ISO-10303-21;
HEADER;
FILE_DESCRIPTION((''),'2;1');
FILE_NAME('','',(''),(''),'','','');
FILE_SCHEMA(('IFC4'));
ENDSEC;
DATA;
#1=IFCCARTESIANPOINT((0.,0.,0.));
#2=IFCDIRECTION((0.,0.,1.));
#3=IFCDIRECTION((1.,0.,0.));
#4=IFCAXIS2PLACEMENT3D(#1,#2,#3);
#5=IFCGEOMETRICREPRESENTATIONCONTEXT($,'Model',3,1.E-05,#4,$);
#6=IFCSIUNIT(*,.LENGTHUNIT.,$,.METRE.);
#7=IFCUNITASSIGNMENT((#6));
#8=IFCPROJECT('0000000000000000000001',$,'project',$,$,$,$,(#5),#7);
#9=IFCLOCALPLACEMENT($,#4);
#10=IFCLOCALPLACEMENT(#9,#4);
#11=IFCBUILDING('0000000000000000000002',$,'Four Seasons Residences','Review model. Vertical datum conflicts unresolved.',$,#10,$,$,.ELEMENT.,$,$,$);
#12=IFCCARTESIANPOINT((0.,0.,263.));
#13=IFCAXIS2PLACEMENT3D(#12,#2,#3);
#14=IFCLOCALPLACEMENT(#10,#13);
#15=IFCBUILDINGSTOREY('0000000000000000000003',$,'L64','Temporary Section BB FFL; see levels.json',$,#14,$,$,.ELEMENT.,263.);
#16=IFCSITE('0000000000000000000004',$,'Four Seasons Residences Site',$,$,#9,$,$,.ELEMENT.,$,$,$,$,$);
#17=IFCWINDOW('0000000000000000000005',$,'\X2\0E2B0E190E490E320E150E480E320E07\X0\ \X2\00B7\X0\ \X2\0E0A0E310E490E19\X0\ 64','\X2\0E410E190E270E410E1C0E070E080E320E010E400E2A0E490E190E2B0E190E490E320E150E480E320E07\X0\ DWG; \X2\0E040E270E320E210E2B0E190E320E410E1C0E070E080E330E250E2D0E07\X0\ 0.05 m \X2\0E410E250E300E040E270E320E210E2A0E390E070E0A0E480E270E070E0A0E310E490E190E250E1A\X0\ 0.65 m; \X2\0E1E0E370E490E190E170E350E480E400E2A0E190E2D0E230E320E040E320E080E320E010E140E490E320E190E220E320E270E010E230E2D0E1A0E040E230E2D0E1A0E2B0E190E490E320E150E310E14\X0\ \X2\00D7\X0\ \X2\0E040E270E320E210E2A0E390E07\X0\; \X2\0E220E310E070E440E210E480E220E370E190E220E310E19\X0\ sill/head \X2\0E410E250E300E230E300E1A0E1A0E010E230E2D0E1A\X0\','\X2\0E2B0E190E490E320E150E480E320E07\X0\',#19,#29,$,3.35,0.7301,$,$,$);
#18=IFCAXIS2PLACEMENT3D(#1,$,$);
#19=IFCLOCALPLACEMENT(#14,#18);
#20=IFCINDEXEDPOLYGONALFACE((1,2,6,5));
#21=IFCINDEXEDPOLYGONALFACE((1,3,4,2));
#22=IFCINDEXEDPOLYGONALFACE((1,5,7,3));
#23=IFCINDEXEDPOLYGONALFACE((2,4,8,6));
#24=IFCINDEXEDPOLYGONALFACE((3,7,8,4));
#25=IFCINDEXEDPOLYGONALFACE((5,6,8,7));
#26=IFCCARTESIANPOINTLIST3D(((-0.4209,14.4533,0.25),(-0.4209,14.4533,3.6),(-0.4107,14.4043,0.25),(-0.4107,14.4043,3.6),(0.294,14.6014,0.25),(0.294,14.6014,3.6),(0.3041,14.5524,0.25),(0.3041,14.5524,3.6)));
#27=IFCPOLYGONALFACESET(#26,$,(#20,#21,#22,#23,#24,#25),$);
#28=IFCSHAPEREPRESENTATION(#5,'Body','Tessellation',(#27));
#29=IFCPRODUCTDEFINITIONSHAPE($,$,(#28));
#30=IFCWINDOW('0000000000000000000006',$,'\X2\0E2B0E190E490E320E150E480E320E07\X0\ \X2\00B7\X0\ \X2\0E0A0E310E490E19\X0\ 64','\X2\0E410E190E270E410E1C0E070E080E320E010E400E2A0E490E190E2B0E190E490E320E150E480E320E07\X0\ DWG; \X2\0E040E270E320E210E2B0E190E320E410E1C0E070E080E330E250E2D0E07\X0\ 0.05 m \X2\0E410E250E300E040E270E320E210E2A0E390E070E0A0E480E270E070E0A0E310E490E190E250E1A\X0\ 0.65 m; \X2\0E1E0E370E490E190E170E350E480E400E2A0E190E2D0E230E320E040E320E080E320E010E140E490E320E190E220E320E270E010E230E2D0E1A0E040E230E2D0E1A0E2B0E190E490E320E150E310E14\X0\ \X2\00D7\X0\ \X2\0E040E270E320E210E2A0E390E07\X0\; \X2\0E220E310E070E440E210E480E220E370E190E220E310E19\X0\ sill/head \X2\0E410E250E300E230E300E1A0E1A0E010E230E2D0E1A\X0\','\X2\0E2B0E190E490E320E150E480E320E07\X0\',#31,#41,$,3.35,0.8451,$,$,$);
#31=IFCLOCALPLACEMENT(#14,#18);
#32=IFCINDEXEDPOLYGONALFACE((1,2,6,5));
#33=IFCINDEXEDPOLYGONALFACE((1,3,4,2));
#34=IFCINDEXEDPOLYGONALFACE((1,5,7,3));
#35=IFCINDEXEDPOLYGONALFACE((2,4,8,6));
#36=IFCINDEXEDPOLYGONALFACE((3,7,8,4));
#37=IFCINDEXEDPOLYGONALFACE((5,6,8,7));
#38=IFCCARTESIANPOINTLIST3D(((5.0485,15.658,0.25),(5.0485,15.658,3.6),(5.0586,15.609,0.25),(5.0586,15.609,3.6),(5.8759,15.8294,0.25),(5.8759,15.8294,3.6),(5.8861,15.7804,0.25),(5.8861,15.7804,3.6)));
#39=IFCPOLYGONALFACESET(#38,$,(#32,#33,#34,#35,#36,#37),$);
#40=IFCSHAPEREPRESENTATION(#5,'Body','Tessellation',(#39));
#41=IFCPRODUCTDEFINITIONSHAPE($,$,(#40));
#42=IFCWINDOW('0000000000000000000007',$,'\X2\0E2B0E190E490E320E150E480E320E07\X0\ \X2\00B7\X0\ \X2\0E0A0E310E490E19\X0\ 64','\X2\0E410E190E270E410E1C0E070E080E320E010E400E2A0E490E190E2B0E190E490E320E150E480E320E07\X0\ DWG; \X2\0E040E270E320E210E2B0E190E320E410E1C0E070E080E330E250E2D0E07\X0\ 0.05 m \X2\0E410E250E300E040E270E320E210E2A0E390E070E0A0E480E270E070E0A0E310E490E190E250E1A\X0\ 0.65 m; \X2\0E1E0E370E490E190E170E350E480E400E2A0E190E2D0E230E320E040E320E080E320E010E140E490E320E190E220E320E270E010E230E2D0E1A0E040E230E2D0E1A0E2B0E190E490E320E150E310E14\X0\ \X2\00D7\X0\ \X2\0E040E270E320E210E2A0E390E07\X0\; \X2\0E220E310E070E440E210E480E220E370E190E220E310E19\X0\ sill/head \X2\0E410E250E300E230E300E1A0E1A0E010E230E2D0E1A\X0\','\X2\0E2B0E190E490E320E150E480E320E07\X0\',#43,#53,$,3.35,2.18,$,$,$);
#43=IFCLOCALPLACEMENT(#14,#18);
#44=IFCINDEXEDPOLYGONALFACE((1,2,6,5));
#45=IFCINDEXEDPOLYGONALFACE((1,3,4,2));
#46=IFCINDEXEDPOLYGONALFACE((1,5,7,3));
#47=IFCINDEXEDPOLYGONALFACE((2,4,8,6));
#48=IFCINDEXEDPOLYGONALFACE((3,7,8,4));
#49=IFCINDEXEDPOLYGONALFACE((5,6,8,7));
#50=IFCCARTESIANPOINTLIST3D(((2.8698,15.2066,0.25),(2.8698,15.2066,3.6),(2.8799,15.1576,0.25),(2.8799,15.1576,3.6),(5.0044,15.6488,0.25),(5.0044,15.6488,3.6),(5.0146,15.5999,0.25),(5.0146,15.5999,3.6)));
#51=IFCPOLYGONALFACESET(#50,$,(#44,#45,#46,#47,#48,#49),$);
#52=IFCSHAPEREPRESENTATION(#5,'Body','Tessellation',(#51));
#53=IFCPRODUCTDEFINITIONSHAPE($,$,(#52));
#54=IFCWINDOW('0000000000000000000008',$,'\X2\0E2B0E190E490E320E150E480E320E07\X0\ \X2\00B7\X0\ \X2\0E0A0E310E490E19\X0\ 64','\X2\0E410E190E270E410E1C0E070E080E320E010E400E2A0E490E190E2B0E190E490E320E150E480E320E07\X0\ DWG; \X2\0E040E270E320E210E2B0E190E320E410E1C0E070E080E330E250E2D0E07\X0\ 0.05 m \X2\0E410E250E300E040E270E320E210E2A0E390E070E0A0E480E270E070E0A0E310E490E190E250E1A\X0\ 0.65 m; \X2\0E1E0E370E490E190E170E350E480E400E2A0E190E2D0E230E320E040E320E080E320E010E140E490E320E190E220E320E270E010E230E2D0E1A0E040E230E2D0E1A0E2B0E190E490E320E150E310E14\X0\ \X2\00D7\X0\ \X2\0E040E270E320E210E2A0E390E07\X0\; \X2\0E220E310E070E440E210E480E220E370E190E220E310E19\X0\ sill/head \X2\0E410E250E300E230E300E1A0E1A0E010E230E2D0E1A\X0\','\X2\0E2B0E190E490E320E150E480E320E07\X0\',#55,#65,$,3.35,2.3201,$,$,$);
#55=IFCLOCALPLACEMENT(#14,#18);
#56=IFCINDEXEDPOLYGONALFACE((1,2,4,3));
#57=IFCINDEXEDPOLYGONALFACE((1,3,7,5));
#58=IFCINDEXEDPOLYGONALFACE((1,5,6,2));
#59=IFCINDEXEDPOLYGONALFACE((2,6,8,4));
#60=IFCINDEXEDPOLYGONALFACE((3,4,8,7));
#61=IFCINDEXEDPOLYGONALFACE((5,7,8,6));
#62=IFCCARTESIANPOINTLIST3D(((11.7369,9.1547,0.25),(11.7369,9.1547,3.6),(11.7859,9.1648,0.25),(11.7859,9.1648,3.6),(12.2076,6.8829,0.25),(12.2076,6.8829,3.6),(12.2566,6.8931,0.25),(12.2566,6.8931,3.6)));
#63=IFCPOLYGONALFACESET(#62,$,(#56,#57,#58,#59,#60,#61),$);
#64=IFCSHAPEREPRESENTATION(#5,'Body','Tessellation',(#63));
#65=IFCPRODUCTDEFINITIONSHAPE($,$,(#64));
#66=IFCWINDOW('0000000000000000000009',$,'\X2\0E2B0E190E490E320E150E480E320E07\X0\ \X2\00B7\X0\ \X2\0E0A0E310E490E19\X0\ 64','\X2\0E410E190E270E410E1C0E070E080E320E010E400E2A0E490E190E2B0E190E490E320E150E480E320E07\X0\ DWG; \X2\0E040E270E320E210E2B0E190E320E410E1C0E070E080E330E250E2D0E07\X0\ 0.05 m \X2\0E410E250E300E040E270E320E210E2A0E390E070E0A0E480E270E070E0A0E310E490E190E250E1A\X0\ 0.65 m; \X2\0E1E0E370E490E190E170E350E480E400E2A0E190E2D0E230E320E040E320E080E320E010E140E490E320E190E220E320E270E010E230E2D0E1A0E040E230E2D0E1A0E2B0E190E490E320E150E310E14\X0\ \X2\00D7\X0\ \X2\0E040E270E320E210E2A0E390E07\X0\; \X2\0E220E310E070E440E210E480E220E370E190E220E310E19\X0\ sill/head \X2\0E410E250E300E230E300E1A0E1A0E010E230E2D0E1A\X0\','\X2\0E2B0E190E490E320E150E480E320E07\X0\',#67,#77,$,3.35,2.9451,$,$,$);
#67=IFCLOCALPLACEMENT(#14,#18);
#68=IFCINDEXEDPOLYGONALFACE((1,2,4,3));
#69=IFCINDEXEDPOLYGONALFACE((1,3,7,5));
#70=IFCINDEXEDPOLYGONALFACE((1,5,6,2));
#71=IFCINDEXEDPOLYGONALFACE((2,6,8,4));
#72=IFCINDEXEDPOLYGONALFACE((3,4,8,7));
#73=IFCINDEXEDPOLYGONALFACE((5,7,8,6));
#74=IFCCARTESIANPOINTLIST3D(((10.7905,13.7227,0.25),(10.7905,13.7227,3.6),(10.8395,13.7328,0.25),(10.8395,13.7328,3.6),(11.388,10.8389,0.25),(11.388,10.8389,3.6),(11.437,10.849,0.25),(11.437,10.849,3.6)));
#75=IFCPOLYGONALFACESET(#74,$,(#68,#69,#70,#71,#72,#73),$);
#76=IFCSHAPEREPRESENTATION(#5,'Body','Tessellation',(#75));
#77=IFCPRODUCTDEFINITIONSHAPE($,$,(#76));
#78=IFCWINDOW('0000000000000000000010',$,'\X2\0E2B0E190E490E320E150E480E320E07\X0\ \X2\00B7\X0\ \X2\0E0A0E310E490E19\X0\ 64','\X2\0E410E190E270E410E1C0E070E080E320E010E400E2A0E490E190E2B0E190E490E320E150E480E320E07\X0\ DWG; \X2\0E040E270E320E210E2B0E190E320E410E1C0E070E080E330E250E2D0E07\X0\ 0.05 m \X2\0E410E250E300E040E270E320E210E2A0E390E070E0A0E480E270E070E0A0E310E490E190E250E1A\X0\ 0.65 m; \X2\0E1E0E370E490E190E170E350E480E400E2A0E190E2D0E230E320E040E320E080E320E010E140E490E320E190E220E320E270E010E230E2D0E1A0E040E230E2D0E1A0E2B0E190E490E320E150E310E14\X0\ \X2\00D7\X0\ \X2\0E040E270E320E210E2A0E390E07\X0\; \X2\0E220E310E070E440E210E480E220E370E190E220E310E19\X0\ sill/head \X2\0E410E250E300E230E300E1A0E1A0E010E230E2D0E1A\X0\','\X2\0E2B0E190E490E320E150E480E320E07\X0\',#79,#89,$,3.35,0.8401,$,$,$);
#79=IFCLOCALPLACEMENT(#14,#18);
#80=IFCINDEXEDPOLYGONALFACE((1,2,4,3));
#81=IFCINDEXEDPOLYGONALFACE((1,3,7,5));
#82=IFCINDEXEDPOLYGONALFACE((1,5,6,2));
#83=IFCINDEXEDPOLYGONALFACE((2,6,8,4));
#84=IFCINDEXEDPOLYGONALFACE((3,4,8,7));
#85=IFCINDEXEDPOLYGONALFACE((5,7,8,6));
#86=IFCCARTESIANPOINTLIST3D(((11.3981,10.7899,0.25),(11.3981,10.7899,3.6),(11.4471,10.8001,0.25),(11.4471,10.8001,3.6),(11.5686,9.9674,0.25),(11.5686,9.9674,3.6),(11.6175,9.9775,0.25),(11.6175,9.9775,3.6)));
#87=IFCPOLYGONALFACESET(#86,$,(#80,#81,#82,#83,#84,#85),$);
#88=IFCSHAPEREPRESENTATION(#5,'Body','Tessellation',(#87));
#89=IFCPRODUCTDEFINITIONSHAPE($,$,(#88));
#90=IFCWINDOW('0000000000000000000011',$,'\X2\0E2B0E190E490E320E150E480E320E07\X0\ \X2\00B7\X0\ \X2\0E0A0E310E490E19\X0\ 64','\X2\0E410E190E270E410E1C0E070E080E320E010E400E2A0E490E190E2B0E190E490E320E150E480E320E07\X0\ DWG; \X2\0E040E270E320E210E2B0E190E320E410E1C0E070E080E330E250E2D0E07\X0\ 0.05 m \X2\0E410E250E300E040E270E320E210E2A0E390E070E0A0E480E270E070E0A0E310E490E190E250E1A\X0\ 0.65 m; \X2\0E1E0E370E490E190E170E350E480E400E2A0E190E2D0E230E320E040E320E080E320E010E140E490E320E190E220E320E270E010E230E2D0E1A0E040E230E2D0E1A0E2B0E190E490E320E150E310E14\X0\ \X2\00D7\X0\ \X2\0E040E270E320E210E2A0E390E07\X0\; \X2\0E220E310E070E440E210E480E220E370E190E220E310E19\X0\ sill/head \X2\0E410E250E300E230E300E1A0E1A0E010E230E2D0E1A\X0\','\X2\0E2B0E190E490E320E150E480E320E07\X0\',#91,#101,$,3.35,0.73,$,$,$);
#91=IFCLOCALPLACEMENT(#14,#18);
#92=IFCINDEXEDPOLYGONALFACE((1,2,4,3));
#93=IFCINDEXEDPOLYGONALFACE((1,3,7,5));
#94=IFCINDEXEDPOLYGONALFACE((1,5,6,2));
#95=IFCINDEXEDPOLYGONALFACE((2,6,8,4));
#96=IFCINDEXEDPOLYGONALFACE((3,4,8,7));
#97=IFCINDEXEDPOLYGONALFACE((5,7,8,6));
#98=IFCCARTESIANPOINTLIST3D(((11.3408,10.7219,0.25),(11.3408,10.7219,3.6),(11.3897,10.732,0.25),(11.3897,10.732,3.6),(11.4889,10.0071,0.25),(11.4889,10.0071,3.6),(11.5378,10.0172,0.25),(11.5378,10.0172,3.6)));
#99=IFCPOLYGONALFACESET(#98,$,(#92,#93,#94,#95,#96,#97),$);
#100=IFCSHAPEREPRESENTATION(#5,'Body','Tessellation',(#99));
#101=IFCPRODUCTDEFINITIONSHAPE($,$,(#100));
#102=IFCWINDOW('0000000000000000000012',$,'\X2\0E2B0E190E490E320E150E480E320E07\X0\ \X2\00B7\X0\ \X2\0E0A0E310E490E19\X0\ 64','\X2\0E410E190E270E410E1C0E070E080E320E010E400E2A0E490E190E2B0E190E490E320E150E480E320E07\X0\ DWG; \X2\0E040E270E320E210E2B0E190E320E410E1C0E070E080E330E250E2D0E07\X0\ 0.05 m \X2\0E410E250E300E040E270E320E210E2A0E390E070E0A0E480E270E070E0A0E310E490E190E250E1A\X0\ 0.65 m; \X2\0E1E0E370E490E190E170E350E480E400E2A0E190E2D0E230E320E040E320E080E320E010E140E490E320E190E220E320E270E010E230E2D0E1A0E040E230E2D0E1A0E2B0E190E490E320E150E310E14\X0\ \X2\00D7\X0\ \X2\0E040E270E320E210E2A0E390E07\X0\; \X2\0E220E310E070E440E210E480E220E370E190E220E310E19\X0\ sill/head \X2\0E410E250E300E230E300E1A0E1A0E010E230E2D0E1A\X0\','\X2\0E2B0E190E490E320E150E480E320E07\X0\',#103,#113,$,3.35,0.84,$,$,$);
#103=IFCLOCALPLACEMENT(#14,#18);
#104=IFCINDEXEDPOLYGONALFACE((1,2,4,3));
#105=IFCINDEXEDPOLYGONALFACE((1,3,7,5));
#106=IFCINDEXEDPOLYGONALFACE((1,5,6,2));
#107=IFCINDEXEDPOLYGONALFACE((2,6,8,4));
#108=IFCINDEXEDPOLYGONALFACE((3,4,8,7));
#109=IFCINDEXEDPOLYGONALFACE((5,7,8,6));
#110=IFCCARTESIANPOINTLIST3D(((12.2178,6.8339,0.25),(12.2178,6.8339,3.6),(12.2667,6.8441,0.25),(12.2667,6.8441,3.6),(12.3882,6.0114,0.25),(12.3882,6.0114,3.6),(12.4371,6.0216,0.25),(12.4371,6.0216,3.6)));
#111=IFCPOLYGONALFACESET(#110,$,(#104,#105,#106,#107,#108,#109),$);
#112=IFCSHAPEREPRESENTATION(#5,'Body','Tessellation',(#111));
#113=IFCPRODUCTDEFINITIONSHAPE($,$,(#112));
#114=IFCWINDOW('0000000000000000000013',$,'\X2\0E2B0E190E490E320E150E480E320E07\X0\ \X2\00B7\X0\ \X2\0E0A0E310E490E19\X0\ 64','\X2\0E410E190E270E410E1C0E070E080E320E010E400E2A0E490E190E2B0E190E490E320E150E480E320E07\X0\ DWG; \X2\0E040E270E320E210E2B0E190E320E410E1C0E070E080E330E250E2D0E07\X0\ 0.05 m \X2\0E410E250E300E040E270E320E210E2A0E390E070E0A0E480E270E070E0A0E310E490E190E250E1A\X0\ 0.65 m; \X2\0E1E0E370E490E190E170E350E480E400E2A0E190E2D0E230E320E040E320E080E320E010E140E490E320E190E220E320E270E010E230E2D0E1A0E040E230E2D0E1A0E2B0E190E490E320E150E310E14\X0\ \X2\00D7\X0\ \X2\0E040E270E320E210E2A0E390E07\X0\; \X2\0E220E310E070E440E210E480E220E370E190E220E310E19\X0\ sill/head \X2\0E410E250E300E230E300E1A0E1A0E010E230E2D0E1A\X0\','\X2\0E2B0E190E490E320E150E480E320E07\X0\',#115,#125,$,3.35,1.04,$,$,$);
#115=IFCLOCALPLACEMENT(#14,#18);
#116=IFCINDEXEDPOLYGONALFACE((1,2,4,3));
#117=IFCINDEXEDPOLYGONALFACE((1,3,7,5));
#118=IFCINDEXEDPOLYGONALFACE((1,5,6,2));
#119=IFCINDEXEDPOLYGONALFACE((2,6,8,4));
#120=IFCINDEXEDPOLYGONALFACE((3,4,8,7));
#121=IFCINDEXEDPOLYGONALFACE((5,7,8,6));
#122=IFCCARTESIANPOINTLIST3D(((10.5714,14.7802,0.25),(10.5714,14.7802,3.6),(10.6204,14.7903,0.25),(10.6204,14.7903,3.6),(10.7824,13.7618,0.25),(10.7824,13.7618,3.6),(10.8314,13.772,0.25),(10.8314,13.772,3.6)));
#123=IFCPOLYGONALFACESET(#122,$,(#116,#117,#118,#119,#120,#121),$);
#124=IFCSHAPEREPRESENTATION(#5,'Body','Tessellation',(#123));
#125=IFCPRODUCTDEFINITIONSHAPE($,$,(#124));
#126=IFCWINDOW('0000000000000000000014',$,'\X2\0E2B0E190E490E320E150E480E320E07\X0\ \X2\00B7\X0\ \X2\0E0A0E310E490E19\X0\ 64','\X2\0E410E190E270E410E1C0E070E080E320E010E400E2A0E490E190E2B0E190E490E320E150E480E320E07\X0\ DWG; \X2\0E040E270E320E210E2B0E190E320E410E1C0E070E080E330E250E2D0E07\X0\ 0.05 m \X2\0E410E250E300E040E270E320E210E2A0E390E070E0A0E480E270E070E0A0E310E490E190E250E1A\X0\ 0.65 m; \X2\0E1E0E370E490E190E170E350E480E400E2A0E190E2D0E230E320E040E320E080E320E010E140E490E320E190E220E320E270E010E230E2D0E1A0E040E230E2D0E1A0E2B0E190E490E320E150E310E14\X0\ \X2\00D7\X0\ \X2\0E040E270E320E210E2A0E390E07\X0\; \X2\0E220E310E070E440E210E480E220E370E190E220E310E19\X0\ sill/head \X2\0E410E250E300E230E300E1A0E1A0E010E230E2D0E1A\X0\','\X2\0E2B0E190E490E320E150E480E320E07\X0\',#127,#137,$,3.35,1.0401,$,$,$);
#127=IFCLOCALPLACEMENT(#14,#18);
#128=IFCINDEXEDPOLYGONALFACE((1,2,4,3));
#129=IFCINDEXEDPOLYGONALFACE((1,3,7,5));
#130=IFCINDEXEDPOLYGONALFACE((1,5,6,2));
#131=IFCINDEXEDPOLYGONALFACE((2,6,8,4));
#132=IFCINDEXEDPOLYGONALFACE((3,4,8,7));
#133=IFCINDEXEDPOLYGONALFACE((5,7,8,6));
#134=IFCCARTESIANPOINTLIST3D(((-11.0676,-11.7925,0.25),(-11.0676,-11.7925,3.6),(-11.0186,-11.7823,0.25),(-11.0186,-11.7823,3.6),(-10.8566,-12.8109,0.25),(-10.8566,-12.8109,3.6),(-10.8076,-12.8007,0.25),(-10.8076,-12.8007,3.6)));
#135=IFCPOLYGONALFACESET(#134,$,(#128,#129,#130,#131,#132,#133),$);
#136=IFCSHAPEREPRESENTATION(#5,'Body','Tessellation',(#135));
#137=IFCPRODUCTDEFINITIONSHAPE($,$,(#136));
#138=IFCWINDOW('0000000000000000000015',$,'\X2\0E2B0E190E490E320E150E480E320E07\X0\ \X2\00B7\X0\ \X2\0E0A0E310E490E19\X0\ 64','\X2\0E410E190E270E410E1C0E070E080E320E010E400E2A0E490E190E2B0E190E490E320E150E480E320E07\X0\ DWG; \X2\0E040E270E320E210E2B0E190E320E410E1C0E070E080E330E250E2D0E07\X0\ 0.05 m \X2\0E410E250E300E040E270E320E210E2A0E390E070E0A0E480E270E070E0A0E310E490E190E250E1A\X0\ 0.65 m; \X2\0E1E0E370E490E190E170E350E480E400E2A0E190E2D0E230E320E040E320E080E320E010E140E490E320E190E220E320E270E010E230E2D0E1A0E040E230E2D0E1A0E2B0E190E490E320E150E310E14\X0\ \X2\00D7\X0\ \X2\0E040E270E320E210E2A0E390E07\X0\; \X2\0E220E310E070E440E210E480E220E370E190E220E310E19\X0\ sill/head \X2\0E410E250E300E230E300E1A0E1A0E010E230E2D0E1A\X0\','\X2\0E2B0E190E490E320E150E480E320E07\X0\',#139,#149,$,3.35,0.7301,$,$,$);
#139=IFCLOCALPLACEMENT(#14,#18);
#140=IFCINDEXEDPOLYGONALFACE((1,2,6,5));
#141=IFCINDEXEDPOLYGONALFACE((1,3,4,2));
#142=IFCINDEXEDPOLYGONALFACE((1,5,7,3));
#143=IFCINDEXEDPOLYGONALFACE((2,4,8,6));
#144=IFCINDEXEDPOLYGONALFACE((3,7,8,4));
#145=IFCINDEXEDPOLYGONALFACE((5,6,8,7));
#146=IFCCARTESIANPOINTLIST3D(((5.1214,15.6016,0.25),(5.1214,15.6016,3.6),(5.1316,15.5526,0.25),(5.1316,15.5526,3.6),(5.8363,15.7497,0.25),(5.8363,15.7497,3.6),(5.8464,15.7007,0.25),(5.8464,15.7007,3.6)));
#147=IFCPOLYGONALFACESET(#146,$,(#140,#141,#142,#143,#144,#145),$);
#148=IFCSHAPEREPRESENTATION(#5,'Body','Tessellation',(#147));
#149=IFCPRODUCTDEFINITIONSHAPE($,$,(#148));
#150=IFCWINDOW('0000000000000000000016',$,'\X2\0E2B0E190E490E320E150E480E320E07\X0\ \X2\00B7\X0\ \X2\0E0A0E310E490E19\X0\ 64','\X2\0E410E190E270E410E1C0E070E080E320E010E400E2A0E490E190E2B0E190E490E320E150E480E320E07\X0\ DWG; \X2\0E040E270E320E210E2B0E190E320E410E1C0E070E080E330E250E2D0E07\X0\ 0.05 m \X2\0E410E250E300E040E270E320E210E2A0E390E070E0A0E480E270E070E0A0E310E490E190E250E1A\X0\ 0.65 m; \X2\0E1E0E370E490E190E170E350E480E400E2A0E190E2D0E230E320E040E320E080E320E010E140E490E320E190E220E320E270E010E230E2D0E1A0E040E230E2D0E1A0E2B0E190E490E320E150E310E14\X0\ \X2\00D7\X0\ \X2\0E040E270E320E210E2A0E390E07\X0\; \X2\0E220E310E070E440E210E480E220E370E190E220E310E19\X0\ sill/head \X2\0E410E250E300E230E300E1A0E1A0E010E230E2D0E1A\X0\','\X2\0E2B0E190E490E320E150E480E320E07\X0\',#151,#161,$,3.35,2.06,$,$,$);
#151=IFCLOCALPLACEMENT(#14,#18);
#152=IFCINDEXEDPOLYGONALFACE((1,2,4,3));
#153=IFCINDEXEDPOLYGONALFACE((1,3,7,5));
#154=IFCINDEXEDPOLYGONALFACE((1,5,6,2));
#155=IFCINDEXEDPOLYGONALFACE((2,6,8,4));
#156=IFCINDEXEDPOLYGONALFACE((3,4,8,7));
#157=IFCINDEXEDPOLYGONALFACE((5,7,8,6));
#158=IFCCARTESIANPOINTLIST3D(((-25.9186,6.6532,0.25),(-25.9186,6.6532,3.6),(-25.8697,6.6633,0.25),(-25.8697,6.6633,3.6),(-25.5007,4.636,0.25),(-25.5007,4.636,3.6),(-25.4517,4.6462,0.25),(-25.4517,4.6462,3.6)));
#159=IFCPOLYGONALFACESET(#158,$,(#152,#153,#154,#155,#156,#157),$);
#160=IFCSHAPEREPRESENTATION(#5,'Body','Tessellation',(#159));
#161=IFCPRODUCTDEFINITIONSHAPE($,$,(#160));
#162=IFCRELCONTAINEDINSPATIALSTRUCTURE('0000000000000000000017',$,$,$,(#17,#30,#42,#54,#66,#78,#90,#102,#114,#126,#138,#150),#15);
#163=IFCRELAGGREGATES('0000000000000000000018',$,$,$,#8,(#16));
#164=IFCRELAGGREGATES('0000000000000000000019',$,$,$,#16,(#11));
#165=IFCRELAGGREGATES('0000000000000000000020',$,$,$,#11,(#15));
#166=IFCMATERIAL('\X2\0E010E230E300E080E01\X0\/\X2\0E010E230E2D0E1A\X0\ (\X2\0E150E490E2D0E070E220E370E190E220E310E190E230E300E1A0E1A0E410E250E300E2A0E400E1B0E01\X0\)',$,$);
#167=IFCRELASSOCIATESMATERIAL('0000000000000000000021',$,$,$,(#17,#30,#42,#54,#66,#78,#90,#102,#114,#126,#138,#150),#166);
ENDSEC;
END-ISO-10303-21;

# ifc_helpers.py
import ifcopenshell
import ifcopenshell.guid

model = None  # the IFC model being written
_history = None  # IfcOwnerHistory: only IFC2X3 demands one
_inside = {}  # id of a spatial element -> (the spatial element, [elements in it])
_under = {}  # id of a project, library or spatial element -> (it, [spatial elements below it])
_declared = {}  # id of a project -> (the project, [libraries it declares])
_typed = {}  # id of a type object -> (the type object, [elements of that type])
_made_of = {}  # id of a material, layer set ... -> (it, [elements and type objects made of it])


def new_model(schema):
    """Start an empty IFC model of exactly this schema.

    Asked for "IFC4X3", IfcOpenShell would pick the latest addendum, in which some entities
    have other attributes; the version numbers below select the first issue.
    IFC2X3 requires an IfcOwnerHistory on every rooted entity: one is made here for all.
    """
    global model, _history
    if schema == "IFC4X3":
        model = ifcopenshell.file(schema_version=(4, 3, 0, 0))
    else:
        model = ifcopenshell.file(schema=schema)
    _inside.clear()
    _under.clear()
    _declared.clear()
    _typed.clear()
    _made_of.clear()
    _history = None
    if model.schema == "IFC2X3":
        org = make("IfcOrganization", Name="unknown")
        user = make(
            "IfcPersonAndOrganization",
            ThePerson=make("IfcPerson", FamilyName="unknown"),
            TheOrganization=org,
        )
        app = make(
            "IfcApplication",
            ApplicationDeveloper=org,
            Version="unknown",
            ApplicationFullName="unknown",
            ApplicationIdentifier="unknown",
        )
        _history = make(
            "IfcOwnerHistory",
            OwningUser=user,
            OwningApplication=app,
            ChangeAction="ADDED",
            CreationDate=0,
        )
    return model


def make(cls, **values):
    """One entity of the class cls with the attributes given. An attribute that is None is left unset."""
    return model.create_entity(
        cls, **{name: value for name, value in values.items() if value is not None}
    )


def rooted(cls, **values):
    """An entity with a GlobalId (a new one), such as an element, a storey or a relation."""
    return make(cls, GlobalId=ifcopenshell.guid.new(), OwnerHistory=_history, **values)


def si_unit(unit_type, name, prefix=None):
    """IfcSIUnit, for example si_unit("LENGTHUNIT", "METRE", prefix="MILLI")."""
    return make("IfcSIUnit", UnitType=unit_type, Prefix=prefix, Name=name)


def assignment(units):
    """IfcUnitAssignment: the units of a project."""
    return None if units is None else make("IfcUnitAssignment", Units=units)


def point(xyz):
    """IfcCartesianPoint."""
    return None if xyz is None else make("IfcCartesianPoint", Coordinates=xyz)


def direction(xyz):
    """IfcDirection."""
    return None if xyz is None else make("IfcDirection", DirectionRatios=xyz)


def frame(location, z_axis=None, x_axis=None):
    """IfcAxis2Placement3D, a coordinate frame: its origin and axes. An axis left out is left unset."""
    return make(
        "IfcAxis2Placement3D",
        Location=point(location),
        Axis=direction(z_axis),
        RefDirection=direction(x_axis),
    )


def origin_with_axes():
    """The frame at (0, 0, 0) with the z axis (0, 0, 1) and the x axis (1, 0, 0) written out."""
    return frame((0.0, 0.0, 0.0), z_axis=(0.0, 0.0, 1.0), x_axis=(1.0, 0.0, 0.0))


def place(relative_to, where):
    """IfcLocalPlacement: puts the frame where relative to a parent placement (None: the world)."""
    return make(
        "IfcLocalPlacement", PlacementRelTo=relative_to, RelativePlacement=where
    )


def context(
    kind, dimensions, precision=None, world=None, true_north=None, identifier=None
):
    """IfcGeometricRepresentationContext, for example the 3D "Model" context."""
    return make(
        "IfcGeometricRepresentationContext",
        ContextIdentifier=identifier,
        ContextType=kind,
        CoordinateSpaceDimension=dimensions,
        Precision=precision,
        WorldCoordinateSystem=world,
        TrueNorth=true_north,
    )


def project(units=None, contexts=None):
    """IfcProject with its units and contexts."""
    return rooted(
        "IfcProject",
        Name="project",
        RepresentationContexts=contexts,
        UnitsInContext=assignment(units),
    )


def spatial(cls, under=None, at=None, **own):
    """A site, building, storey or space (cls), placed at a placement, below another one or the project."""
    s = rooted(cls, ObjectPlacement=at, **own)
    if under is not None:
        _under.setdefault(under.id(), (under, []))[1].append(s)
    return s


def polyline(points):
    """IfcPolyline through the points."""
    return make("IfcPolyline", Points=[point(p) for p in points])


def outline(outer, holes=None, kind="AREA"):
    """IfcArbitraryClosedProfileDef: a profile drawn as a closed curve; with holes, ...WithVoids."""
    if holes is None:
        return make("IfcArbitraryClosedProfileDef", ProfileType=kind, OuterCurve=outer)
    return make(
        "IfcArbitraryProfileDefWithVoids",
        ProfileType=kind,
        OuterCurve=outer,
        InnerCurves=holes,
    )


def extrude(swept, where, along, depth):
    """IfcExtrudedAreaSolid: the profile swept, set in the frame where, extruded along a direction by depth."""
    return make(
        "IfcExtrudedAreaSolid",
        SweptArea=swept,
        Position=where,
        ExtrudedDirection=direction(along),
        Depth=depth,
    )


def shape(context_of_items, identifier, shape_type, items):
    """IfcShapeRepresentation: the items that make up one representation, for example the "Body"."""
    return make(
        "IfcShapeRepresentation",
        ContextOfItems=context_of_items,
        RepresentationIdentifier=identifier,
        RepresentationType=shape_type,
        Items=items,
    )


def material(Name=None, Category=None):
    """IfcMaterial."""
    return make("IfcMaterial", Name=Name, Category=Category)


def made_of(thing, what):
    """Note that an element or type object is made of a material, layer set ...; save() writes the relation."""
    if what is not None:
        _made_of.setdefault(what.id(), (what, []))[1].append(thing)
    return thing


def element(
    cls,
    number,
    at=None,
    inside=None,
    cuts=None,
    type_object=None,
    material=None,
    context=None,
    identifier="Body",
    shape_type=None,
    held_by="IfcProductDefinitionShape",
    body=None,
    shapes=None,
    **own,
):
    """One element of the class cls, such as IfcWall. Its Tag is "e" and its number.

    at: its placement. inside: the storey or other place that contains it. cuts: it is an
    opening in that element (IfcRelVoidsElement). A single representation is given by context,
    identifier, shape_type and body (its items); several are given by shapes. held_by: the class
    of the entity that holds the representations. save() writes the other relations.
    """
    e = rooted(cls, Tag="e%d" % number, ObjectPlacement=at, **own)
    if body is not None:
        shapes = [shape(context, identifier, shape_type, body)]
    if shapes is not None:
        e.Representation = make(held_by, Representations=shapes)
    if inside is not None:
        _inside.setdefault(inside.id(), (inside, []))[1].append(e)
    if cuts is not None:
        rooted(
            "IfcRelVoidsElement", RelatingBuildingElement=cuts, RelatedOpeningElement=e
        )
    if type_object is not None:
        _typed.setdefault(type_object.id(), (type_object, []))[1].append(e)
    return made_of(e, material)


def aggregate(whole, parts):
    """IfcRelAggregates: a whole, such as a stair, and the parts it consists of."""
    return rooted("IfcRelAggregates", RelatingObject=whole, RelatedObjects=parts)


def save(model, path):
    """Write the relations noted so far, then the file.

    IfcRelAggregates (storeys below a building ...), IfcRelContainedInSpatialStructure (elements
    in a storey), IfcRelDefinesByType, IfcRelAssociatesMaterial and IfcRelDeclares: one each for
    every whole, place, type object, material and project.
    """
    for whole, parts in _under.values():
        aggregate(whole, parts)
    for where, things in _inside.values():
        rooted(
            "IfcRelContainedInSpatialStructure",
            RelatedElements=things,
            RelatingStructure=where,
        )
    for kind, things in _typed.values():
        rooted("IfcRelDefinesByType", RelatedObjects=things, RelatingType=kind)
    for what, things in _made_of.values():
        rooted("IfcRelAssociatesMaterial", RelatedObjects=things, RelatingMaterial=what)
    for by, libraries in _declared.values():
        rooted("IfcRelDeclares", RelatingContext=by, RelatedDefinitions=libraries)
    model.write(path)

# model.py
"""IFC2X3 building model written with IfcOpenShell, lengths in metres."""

from ifc_helpers import new_model, si_unit, frame, origin_with_axes, place, context, project, spatial, polyline, outline, extrude, material, element, save


model = new_model("IFC2X3")

# Units and contexts
model_context = context("Model", 3, precision=1e-05, world=origin_with_axes())
ifc_project = project(units=[si_unit("LENGTHUNIT", "METRE")], contexts=[model_context])

# Site, building, storey
site_placement = place(None, origin_with_axes())
site = spatial("IfcSite", under=ifc_project, at=site_placement, Name="Four Seasons Residences Site", CompositionType="ELEMENT")
building_placement = place(site_placement, origin_with_axes())
building = spatial("IfcBuilding", under=site, at=building_placement, Name="Four Seasons Residences", Description="Review model. Vertical datum conflicts unresolved.", CompositionType="ELEMENT")
storey_placement = place(building_placement, frame((0.0, 0.0, 263.0), z_axis=(0.0, 0.0, 1.0), x_axis=(1.0, 0.0, 0.0)))
storey = spatial("IfcBuildingStorey", under=building, at=storey_placement, Name="L64", Description="Temporary Section BB FFL; see levels.json", CompositionType="ELEMENT", Elevation=263.0)

# Windows
ifc_material = material(Name="กระจก/กรอบ (ต้องยืนยันระบบและสเปก)")
window_1_placement = place(storey_placement, origin_with_axes())
element("IfcWindow", 1, at=window_1_placement, inside=storey, material=ifc_material, Name="หน้าต่าง · ชั้น 64", Description="แนวแผงจากเส้นหน้าต่าง DWG; ความหนาแผงจำลอง 0.05 m และความสูงช่วงชั้นลบ 0.65 m; พื้นที่เสนอราคาจากด้านยาวกรอบครอบหน้าตัด × ความสูง; ยังไม่ยืนยัน sill/head และระบบกรอบ", ObjectType="หน้าต่าง", OverallHeight=3.35, OverallWidth=0.7301, context=model_context, shape_type="SweptSolid", body=[
    extrude(outline(polyline([(-0.4107, 14.4043), (-0.4209, 14.4533), (0.294, 14.6014), (0.3041, 14.5524), (-0.4107, 14.4043)])), frame((0.0, 0.0, 0.25), z_axis=(0.0, 0.0, 1.0), x_axis=(1.0, 0.0, 0.0)), (0.0, 0.0, 1.0), 3.35),
])
window_2_placement = place(storey_placement, origin_with_axes())
element("IfcWindow", 2, at=window_2_placement, inside=storey, material=ifc_material, Name="หน้าต่าง · ชั้น 64", Description="แนวแผงจากเส้นหน้าต่าง DWG; ความหนาแผงจำลอง 0.05 m และความสูงช่วงชั้นลบ 0.65 m; พื้นที่เสนอราคาจากด้านยาวกรอบครอบหน้าตัด × ความสูง; ยังไม่ยืนยัน sill/head และระบบกรอบ", ObjectType="หน้าต่าง", OverallHeight=3.35, OverallWidth=0.8451, context=model_context, shape_type="SweptSolid", body=[
    extrude(outline(polyline([(5.0586, 15.609), (5.0485, 15.658), (5.8759, 15.8294), (5.8861, 15.7804), (5.0586, 15.609)])), frame((0.0, 0.0, 0.25), z_axis=(0.0, 0.0, 1.0), x_axis=(1.0, 0.0, 0.0)), (0.0, 0.0, 1.0), 3.35),
])
window_3_placement = place(storey_placement, origin_with_axes())
element("IfcWindow", 3, at=window_3_placement, inside=storey, material=ifc_material, Name="หน้าต่าง · ชั้น 64", Description="แนวแผงจากเส้นหน้าต่าง DWG; ความหนาแผงจำลอง 0.05 m และความสูงช่วงชั้นลบ 0.65 m; พื้นที่เสนอราคาจากด้านยาวกรอบครอบหน้าตัด × ความสูง; ยังไม่ยืนยัน sill/head และระบบกรอบ", ObjectType="หน้าต่าง", OverallHeight=3.35, OverallWidth=2.18, context=model_context, shape_type="SweptSolid", body=[
    extrude(outline(polyline([(2.8799, 15.1576), (2.8698, 15.2066), (5.0044, 15.6488), (5.0146, 15.5999), (2.8799, 15.1576)])), frame((0.0, 0.0, 0.25), z_axis=(0.0, 0.0, 1.0), x_axis=(1.0, 0.0, 0.0)), (0.0, 0.0, 1.0), 3.35),
])
window_4_placement = place(storey_placement, origin_with_axes())
element("IfcWindow", 4, at=window_4_placement, inside=storey, material=ifc_material, Name="หน้าต่าง · ชั้น 64", Description="แนวแผงจากเส้นหน้าต่าง DWG; ความหนาแผงจำลอง 0.05 m และความสูงช่วงชั้นลบ 0.65 m; พื้นที่เสนอราคาจากด้านยาวกรอบครอบหน้าตัด × ความสูง; ยังไม่ยืนยัน sill/head และระบบกรอบ", ObjectType="หน้าต่าง", OverallHeight=3.35, OverallWidth=2.3201, context=model_context, shape_type="SweptSolid", body=[
    extrude(outline(polyline([(11.7369, 9.1547), (11.7859, 9.1648), (12.2566, 6.8931), (12.2076, 6.8829), (11.7369, 9.1547)])), frame((0.0, 0.0, 0.25), z_axis=(0.0, 0.0, 1.0), x_axis=(1.0, 0.0, 0.0)), (0.0, 0.0, 1.0), 3.35),
])
window_5_placement = place(storey_placement, origin_with_axes())
element("IfcWindow", 5, at=window_5_placement, inside=storey, material=ifc_material, Name="หน้าต่าง · ชั้น 64", Description="แนวแผงจากเส้นหน้าต่าง DWG; ความหนาแผงจำลอง 0.05 m และความสูงช่วงชั้นลบ 0.65 m; พื้นที่เสนอราคาจากด้านยาวกรอบครอบหน้าตัด × ความสูง; ยังไม่ยืนยัน sill/head และระบบกรอบ", ObjectType="หน้าต่าง", OverallHeight=3.35, OverallWidth=2.9451, context=model_context, shape_type="SweptSolid", body=[
    extrude(outline(polyline([(11.437, 10.849), (11.388, 10.8389), (10.7905, 13.7227), (10.8395, 13.7328), (11.437, 10.849)])), frame((0.0, 0.0, 0.25), z_axis=(0.0, 0.0, 1.0), x_axis=(1.0, 0.0, 0.0)), (0.0, 0.0, 1.0), 3.35),
])
window_6_placement = place(storey_placement, origin_with_axes())
element("IfcWindow", 6, at=window_6_placement, inside=storey, material=ifc_material, Name="หน้าต่าง · ชั้น 64", Description="แนวแผงจากเส้นหน้าต่าง DWG; ความหนาแผงจำลอง 0.05 m และความสูงช่วงชั้นลบ 0.65 m; พื้นที่เสนอราคาจากด้านยาวกรอบครอบหน้าตัด × ความสูง; ยังไม่ยืนยัน sill/head และระบบกรอบ", ObjectType="หน้าต่าง", OverallHeight=3.35, OverallWidth=0.8401, context=model_context, shape_type="SweptSolid", body=[
    extrude(outline(polyline([(11.6175, 9.9775), (11.5686, 9.9674), (11.3981, 10.7899), (11.4471, 10.8001), (11.6175, 9.9775)])), frame((0.0, 0.0, 0.25), z_axis=(0.0, 0.0, 1.0), x_axis=(1.0, 0.0, 0.0)), (0.0, 0.0, 1.0), 3.35),
])
window_7_placement = place(storey_placement, origin_with_axes())
element("IfcWindow", 7, at=window_7_placement, inside=storey, material=ifc_material, Name="หน้าต่าง · ชั้น 64", Description="แนวแผงจากเส้นหน้าต่าง DWG; ความหนาแผงจำลอง 0.05 m และความสูงช่วงชั้นลบ 0.65 m; พื้นที่เสนอราคาจากด้านยาวกรอบครอบหน้าตัด × ความสูง; ยังไม่ยืนยัน sill/head และระบบกรอบ", ObjectType="หน้าต่าง", OverallHeight=3.35, OverallWidth=0.73, context=model_context, shape_type="SweptSolid", body=[
    extrude(outline(polyline([(11.5378, 10.0172), (11.4889, 10.0071), (11.3408, 10.7219), (11.3897, 10.732), (11.5378, 10.0172)])), frame((0.0, 0.0, 0.25), z_axis=(0.0, 0.0, 1.0), x_axis=(1.0, 0.0, 0.0)), (0.0, 0.0, 1.0), 3.35),
])
window_8_placement = place(storey_placement, origin_with_axes())
element("IfcWindow", 8, at=window_8_placement, inside=storey, material=ifc_material, Name="หน้าต่าง · ชั้น 64", Description="แนวแผงจากเส้นหน้าต่าง DWG; ความหนาแผงจำลอง 0.05 m และความสูงช่วงชั้นลบ 0.65 m; พื้นที่เสนอราคาจากด้านยาวกรอบครอบหน้าตัด × ความสูง; ยังไม่ยืนยัน sill/head และระบบกรอบ", ObjectType="หน้าต่าง", OverallHeight=3.35, OverallWidth=0.84, context=model_context, shape_type="SweptSolid", body=[
    extrude(outline(polyline([(12.2178, 6.8339), (12.2667, 6.8441), (12.4371, 6.0216), (12.3882, 6.0114), (12.2178, 6.8339)])), frame((0.0, 0.0, 0.25), z_axis=(0.0, 0.0, 1.0), x_axis=(1.0, 0.0, 0.0)), (0.0, 0.0, 1.0), 3.35),
])
window_9_placement = place(storey_placement, origin_with_axes())
element("IfcWindow", 9, at=window_9_placement, inside=storey, material=ifc_material, Name="หน้าต่าง · ชั้น 64", Description="แนวแผงจากเส้นหน้าต่าง DWG; ความหนาแผงจำลอง 0.05 m และความสูงช่วงชั้นลบ 0.65 m; พื้นที่เสนอราคาจากด้านยาวกรอบครอบหน้าตัด × ความสูง; ยังไม่ยืนยัน sill/head และระบบกรอบ", ObjectType="หน้าต่าง", OverallHeight=3.35, OverallWidth=1.04, context=model_context, shape_type="SweptSolid", body=[
    extrude(outline(polyline([(10.5714, 14.7802), (10.6204, 14.7903), (10.8314, 13.772), (10.7824, 13.7618), (10.5714, 14.7802)])), frame((0.0, 0.0, 0.25), z_axis=(0.0, 0.0, 1.0), x_axis=(1.0, 0.0, 0.0)), (0.0, 0.0, 1.0), 3.35),
])
window_10_placement = place(storey_placement, origin_with_axes())
element("IfcWindow", 10, at=window_10_placement, inside=storey, material=ifc_material, Name="หน้าต่าง · ชั้น 64", Description="แนวแผงจากเส้นหน้าต่าง DWG; ความหนาแผงจำลอง 0.05 m และความสูงช่วงชั้นลบ 0.65 m; พื้นที่เสนอราคาจากด้านยาวกรอบครอบหน้าตัด × ความสูง; ยังไม่ยืนยัน sill/head และระบบกรอบ", ObjectType="หน้าต่าง", OverallHeight=3.35, OverallWidth=1.0401, context=model_context, shape_type="SweptSolid", body=[
    extrude(outline(polyline([(-10.8076, -12.8007), (-10.8566, -12.8109), (-11.0676, -11.7925), (-11.0186, -11.7823), (-10.8076, -12.8007)])), frame((0.0, 0.0, 0.25), z_axis=(0.0, 0.0, 1.0), x_axis=(1.0, 0.0, 0.0)), (0.0, 0.0, 1.0), 3.35),
])
window_11_placement = place(storey_placement, origin_with_axes())
element("IfcWindow", 11, at=window_11_placement, inside=storey, material=ifc_material, Name="หน้าต่าง · ชั้น 64", Description="แนวแผงจากเส้นหน้าต่าง DWG; ความหนาแผงจำลอง 0.05 m และความสูงช่วงชั้นลบ 0.65 m; พื้นที่เสนอราคาจากด้านยาวกรอบครอบหน้าตัด × ความสูง; ยังไม่ยืนยัน sill/head และระบบกรอบ", ObjectType="หน้าต่าง", OverallHeight=3.35, OverallWidth=0.7301, context=model_context, shape_type="SweptSolid", body=[
    extrude(outline(polyline([(5.1316, 15.5526), (5.1214, 15.6016), (5.8363, 15.7497), (5.8464, 15.7007), (5.1316, 15.5526)])), frame((0.0, 0.0, 0.25), z_axis=(0.0, 0.0, 1.0), x_axis=(1.0, 0.0, 0.0)), (0.0, 0.0, 1.0), 3.35),
])
window_12_placement = place(storey_placement, origin_with_axes())
element("IfcWindow", 12, at=window_12_placement, inside=storey, material=ifc_material, Name="หน้าต่าง · ชั้น 64", Description="แนวแผงจากเส้นหน้าต่าง DWG; ความหนาแผงจำลอง 0.05 m และความสูงช่วงชั้นลบ 0.65 m; พื้นที่เสนอราคาจากด้านยาวกรอบครอบหน้าตัด × ความสูง; ยังไม่ยืนยัน sill/head และระบบกรอบ", ObjectType="หน้าต่าง", OverallHeight=3.35, OverallWidth=2.06, context=model_context, shape_type="SweptSolid", body=[
    extrude(outline(polyline([(-25.4517, 4.6462), (-25.5007, 4.636), (-25.9186, 6.6532), (-25.8697, 6.6633), (-25.4517, 4.6462)])), frame((0.0, 0.0, 0.25), z_axis=(0.0, 0.0, 1.0), x_axis=(1.0, 0.0, 0.0)), (0.0, 0.0, 1.0), 3.35),
])

save(model, "model.ifc")
